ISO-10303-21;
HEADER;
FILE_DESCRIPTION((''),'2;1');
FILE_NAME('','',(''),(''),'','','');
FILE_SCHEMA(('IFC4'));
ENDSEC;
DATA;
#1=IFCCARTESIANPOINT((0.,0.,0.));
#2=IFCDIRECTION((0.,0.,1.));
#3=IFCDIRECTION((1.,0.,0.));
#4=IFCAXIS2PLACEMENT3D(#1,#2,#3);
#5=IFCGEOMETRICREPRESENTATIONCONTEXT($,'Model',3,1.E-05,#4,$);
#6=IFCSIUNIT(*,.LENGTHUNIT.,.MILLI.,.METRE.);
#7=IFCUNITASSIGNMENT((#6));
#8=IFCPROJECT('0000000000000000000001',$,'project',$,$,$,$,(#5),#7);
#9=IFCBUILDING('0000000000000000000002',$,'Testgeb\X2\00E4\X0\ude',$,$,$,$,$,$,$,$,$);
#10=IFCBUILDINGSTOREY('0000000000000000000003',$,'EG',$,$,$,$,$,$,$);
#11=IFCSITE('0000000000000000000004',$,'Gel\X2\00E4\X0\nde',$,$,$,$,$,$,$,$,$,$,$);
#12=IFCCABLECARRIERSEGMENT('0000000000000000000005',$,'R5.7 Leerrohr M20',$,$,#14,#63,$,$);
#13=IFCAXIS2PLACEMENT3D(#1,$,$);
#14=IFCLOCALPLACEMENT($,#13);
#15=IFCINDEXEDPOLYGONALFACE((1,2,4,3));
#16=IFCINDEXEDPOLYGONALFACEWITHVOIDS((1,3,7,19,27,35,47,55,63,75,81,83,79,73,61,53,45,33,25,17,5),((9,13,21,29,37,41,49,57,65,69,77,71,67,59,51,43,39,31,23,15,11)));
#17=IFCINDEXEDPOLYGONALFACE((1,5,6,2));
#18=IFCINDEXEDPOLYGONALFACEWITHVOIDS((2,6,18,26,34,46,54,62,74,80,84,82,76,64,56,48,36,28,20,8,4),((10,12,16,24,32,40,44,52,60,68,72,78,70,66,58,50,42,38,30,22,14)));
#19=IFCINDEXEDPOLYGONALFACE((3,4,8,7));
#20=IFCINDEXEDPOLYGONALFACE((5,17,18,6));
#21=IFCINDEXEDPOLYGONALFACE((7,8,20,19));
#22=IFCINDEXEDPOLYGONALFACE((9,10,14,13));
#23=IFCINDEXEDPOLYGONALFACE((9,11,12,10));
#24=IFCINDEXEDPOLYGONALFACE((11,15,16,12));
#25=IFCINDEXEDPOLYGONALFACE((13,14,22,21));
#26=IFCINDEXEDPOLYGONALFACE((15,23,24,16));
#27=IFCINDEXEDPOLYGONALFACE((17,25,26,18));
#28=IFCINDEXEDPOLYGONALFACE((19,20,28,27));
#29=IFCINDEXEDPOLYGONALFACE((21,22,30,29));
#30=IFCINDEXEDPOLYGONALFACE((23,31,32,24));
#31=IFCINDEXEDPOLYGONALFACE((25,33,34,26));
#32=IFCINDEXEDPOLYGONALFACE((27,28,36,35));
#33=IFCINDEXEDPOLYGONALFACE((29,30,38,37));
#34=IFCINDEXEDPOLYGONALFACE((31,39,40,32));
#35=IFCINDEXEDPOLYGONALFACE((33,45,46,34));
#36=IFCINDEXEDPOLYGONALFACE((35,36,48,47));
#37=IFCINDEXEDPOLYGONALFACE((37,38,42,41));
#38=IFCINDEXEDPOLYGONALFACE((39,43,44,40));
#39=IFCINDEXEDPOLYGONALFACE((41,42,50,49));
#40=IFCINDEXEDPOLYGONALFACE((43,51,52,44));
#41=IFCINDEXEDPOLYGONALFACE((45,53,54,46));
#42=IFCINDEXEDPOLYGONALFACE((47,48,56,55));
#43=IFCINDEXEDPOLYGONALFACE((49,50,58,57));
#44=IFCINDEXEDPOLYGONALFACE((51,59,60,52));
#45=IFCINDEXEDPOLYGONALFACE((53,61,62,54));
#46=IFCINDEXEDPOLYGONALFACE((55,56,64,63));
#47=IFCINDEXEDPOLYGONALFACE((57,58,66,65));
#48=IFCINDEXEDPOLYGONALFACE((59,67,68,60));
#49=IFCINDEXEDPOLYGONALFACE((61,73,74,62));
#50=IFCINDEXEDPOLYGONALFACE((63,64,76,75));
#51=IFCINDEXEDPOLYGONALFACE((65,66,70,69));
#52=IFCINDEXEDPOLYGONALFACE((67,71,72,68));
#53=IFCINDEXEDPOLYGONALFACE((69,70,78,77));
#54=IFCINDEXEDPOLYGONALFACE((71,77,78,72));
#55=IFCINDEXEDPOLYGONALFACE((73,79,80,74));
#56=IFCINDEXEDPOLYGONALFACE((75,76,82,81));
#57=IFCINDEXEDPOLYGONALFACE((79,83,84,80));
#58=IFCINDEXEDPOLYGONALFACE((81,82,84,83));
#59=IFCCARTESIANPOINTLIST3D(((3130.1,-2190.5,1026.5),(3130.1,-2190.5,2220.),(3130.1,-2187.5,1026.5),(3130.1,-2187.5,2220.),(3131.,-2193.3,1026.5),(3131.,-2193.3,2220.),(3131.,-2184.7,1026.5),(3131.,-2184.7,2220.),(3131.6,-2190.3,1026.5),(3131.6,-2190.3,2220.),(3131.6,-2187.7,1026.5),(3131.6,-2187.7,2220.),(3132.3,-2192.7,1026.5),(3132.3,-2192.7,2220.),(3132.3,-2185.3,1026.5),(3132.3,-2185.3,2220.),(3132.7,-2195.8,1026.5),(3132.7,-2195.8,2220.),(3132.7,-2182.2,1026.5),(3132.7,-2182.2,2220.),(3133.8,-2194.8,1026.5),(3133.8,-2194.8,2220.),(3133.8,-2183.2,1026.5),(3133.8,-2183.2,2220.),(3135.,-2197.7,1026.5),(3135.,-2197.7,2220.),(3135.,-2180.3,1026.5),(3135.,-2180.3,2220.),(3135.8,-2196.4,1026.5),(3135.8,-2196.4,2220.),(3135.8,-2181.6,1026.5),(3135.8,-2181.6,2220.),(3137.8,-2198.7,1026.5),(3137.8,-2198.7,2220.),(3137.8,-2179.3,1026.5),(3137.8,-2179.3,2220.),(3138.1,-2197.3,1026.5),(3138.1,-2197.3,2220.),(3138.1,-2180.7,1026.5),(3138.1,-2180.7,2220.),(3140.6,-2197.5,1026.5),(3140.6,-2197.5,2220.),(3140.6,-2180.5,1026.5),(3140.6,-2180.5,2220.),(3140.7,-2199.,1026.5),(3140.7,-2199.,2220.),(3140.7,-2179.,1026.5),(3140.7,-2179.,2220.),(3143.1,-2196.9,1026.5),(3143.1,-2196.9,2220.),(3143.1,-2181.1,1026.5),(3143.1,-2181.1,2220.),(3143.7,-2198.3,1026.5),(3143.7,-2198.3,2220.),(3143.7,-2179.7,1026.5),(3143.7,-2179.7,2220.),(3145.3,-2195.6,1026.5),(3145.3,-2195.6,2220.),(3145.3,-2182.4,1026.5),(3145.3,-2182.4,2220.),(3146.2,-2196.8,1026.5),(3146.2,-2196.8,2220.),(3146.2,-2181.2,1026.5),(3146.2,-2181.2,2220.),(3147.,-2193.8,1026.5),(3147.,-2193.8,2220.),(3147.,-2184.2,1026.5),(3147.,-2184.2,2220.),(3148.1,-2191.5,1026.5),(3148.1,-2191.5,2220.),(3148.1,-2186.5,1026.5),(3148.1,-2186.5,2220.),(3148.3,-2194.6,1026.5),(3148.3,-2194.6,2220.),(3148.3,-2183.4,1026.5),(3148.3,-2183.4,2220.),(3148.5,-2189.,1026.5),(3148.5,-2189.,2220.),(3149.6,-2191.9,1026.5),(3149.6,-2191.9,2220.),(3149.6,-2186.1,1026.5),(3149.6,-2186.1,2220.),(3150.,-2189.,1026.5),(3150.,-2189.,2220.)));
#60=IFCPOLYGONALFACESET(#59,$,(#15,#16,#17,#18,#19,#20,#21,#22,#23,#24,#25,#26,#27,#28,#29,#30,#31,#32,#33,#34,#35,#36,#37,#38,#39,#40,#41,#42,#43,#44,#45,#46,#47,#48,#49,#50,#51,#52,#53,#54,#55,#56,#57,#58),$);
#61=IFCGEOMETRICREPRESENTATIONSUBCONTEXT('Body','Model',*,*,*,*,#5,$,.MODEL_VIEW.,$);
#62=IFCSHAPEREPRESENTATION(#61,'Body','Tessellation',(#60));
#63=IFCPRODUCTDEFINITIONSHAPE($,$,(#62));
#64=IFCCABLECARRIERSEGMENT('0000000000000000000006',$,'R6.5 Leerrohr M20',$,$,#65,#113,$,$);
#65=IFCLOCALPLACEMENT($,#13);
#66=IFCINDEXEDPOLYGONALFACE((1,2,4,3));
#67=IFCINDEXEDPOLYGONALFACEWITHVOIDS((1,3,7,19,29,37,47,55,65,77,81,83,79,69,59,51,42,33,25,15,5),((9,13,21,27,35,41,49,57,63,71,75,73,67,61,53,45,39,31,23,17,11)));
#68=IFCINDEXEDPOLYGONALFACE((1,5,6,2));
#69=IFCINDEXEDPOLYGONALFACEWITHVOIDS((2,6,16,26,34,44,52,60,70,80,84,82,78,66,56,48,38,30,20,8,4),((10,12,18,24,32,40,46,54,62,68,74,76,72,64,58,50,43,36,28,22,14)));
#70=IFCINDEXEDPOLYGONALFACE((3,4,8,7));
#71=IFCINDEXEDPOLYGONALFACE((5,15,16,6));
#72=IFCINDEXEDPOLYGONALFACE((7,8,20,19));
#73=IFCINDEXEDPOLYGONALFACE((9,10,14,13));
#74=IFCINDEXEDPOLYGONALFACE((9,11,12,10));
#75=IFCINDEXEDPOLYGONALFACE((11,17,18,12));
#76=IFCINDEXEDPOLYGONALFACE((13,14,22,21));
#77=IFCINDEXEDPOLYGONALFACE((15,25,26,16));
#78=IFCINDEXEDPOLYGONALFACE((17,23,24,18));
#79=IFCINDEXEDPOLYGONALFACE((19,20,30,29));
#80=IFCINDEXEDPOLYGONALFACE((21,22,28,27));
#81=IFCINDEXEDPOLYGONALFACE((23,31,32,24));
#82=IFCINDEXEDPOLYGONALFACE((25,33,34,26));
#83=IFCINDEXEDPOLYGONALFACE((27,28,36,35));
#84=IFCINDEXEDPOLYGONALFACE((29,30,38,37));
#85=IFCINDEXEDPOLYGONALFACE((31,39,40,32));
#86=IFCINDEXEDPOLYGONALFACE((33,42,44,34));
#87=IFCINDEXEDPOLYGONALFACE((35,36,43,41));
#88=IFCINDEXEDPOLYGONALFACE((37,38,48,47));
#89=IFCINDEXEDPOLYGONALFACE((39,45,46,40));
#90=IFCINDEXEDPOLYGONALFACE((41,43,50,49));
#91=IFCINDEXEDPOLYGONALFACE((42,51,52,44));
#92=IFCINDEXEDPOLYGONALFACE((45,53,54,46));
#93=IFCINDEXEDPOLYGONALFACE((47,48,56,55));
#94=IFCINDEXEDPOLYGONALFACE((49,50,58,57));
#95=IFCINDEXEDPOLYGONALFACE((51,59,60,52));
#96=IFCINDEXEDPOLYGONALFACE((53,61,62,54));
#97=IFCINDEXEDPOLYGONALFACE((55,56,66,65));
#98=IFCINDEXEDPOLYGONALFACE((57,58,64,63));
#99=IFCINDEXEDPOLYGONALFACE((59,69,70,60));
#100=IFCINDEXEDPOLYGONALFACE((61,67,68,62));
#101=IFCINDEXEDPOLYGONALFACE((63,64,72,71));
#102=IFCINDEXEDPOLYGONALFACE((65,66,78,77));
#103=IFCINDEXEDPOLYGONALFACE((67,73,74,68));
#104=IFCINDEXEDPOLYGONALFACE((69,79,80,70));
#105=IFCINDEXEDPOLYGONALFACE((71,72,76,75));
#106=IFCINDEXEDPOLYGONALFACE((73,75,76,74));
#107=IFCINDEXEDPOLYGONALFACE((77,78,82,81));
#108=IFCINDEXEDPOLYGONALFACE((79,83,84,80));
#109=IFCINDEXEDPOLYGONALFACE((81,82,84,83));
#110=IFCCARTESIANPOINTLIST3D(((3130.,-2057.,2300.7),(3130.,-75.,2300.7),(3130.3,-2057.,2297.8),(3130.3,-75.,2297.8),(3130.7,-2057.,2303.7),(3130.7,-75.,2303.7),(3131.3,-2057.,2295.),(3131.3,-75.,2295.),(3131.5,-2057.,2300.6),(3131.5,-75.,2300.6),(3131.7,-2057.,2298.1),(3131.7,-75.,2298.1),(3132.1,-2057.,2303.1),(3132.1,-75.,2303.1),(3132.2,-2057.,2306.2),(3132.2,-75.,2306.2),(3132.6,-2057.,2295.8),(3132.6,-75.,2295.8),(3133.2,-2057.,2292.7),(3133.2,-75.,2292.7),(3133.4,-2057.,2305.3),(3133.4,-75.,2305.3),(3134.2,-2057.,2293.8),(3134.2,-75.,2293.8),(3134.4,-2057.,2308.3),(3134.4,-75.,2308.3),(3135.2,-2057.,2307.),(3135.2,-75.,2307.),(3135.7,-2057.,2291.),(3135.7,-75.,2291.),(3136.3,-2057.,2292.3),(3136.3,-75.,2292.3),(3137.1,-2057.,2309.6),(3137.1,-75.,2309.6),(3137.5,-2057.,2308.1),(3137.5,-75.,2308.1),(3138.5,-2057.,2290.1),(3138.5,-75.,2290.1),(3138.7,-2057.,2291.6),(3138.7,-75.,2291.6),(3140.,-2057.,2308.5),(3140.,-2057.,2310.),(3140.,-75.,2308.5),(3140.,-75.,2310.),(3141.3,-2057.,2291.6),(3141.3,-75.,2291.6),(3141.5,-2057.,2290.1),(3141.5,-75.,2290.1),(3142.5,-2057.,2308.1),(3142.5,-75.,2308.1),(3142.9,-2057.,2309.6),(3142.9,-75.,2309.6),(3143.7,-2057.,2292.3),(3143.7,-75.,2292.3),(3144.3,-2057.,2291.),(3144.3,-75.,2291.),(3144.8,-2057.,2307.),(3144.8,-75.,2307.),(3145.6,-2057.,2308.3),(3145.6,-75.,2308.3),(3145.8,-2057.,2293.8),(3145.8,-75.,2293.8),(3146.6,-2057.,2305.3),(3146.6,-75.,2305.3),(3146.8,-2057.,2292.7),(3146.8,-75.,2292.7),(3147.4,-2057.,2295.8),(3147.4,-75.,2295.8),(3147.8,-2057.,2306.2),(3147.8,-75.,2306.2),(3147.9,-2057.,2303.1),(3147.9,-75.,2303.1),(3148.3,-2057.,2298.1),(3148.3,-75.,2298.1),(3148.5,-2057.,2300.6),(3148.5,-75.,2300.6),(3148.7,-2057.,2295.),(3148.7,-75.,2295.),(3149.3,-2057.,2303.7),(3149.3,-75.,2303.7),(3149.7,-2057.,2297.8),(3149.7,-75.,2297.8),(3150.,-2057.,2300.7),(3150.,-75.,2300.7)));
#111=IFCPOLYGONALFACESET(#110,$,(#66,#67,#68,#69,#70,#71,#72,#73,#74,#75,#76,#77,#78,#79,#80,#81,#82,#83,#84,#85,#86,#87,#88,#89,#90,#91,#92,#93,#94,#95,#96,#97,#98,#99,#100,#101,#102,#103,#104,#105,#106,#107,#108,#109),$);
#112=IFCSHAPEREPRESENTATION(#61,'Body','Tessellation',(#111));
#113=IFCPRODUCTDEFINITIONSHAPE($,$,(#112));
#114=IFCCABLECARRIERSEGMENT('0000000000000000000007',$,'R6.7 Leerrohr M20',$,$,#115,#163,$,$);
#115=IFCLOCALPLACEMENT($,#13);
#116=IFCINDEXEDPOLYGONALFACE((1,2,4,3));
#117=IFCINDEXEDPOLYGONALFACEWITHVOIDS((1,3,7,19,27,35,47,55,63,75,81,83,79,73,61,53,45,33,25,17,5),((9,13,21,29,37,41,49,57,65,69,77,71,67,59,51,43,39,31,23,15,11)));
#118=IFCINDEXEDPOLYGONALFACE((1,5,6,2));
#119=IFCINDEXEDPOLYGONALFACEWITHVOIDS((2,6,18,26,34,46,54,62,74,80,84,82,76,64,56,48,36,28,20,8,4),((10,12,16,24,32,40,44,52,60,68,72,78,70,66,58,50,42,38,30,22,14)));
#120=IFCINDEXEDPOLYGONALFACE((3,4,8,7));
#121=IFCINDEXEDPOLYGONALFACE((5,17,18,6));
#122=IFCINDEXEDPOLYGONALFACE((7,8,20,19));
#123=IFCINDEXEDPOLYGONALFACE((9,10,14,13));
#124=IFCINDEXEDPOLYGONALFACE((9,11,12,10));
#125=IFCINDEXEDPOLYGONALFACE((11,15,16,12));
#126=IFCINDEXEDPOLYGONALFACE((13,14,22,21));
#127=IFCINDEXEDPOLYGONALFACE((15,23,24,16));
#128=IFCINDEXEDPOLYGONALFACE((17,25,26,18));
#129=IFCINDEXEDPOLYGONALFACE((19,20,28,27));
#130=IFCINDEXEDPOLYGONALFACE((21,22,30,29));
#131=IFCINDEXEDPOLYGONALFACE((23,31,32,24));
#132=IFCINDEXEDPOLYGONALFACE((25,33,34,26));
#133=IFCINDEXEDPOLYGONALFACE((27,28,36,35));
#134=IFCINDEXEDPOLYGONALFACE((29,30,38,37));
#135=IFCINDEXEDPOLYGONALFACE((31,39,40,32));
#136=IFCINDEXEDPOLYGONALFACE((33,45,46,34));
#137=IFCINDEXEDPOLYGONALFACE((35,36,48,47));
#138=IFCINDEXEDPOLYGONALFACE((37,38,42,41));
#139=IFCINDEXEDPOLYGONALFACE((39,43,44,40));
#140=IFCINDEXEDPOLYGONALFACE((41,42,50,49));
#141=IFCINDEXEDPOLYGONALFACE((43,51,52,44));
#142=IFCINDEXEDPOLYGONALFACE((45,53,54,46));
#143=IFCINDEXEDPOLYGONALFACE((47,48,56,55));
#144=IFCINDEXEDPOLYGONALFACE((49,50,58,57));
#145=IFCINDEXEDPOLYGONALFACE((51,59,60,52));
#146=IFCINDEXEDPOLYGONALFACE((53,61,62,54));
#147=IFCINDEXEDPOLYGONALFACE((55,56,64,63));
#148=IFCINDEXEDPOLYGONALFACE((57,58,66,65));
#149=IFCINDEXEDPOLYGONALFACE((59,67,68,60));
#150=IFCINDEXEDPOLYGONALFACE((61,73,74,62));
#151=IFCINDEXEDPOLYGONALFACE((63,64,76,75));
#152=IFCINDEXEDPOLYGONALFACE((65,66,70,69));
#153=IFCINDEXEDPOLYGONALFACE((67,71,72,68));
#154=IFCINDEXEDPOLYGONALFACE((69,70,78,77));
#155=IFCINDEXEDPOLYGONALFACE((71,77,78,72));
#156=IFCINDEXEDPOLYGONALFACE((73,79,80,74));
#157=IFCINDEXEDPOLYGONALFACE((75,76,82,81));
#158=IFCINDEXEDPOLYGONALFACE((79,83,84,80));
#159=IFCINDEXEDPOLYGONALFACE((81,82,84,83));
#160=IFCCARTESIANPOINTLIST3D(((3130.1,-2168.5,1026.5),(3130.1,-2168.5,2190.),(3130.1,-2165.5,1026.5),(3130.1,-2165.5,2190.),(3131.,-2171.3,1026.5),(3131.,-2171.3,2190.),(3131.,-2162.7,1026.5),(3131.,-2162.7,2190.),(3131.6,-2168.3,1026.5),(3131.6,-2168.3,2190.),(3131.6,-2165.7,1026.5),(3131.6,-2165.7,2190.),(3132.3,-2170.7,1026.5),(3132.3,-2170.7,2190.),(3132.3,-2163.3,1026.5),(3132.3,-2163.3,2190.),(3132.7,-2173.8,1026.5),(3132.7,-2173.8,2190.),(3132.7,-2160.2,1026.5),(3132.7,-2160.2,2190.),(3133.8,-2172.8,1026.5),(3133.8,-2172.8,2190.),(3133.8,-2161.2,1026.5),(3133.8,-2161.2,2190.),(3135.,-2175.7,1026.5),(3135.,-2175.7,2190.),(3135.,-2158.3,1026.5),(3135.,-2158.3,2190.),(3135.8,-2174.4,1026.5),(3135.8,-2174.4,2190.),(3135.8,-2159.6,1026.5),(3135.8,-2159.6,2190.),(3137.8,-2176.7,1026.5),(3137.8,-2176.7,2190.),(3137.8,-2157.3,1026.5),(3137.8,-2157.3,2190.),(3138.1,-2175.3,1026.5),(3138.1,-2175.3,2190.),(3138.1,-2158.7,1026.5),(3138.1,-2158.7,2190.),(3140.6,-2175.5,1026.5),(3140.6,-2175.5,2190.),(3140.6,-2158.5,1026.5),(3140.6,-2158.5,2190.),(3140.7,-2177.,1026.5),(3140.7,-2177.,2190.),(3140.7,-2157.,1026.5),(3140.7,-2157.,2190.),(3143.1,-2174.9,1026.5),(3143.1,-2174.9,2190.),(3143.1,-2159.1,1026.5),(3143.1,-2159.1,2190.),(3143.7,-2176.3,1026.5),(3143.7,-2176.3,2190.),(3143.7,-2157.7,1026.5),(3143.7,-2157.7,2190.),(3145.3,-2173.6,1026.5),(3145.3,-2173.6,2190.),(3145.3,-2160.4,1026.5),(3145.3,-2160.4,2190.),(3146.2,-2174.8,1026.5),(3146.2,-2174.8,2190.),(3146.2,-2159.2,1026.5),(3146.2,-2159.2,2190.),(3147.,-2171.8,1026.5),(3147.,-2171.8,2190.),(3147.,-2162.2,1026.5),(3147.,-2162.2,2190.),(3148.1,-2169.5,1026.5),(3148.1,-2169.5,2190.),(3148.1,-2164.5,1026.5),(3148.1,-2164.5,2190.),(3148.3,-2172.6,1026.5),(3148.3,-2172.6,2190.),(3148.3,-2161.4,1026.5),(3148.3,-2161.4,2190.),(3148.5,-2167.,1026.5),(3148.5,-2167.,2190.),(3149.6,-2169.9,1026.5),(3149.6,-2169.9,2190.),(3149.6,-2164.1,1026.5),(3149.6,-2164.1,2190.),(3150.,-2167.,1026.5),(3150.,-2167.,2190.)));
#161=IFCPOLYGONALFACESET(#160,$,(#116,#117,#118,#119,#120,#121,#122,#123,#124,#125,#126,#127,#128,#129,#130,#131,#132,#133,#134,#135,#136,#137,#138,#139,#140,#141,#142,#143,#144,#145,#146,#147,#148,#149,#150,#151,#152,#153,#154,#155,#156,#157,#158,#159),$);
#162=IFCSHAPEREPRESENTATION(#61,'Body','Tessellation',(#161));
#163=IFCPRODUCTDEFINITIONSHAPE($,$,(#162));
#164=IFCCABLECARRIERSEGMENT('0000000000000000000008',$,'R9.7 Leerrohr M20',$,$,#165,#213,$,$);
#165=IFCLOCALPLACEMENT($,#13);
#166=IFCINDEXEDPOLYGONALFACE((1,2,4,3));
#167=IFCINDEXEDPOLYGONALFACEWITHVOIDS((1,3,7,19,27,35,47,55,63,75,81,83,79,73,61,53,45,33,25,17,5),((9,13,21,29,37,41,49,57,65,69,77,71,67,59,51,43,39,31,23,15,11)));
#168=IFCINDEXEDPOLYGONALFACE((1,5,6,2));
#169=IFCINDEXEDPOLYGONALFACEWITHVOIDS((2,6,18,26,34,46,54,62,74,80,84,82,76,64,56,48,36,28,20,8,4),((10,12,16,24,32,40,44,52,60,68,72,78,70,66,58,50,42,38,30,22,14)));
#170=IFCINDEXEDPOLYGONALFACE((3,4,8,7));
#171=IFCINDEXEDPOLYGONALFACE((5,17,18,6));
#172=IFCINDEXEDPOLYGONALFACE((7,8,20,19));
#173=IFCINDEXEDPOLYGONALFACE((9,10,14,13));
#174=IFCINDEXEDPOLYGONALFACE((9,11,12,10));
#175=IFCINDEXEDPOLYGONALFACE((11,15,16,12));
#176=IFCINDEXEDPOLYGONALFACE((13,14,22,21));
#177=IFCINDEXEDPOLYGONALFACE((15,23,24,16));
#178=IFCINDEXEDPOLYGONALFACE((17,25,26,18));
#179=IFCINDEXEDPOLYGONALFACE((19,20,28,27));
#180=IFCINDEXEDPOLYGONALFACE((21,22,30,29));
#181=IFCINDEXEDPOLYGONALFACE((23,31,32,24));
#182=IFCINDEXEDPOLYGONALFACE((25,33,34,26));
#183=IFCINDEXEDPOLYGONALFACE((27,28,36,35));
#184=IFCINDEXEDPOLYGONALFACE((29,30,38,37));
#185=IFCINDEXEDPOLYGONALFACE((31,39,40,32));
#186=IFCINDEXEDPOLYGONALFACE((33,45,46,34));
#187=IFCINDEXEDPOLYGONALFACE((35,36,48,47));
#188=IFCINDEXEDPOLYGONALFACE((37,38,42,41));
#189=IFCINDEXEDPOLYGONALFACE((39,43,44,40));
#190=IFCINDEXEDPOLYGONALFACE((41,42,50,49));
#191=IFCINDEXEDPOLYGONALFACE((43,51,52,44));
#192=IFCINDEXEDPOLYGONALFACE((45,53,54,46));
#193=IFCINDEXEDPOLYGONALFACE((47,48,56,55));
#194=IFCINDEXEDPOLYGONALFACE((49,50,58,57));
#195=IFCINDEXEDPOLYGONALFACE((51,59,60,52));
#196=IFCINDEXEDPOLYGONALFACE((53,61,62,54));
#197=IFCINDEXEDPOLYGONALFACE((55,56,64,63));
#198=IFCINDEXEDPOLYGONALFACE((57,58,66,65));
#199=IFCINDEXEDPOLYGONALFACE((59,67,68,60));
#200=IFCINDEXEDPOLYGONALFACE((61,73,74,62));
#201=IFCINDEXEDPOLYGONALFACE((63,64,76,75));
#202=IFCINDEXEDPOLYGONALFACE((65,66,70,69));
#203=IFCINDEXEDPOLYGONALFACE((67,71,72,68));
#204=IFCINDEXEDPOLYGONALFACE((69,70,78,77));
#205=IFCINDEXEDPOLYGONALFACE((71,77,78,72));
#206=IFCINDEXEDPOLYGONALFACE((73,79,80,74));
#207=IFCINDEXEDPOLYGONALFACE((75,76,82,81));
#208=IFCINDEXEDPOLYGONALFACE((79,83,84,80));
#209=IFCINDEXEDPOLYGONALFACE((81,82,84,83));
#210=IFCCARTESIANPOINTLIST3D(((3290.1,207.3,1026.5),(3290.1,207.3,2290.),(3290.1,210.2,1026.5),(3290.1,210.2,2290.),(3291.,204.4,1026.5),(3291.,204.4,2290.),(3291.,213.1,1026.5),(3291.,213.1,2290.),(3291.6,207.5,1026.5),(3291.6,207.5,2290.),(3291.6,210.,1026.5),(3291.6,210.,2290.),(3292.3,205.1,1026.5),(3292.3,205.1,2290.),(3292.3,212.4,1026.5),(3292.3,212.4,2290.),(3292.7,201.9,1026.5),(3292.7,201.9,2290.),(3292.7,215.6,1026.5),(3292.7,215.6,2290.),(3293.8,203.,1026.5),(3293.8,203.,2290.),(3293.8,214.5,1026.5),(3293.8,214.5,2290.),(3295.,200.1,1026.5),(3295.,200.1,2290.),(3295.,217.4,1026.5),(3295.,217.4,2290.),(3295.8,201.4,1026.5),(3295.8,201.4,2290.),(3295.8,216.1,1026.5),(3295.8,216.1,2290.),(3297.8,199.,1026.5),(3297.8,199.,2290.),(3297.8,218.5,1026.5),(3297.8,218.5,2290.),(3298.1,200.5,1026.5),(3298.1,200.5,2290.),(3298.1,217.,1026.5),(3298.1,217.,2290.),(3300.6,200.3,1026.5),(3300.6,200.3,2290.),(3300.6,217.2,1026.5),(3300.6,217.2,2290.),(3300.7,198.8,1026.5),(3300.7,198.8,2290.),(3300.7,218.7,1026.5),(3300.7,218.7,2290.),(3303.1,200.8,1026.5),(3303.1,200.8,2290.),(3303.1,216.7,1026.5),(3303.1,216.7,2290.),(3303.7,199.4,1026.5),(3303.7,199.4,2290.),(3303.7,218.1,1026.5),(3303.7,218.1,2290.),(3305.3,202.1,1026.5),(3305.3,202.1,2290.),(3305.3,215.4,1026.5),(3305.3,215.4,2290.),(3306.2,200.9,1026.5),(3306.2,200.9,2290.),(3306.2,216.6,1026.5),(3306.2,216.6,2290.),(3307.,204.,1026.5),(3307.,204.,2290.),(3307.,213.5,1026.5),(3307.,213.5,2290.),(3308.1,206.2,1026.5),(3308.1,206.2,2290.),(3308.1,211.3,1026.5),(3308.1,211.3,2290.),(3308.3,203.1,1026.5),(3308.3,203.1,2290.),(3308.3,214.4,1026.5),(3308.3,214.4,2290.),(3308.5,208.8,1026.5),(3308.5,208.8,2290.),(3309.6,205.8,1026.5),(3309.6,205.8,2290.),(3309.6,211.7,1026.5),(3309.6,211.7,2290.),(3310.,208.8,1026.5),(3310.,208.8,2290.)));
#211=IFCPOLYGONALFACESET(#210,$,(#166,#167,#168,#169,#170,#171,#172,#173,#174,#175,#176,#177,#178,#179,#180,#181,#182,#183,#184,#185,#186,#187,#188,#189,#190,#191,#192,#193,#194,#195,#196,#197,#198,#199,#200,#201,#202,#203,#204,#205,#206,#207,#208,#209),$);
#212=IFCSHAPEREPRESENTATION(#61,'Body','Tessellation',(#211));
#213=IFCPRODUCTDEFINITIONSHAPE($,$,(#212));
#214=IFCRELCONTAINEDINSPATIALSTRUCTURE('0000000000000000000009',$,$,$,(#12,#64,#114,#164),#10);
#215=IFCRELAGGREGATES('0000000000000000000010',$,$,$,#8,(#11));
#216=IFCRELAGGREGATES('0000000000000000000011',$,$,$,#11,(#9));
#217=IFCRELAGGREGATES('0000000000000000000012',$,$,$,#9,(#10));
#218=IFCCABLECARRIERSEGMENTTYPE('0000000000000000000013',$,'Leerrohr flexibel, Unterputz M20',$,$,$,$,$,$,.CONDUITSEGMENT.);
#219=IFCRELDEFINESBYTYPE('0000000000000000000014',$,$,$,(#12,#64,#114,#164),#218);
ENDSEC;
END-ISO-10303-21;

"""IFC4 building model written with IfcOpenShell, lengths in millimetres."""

from ifc_helpers import new_model, si_unit, frame, origin_with_axes, place, context, subcontext, project, spatial, hollow_circle, extrude, type_object, element, save


model = new_model("IFC4")

# Units and contexts
model_context = context("Model", 3, precision=1e-05, world=origin_with_axes())
body_context = subcontext(model_context, "Body", "Model", "MODEL_VIEW")
ifc_project = project(units=[si_unit("LENGTHUNIT", "METRE", prefix="MILLI")], contexts=[model_context])

# Site, building, storey
site = spatial("IfcSite", under=ifc_project, Name="Gelände")
building = spatial("IfcBuilding", under=site, Name="Testgebäude")
storey = spatial("IfcBuildingStorey", under=building, Name="EG")

# Cable carrier segments
cable_carrier_segment_type_1 = type_object("IfcCableCarrierSegmentType", Name="Leerrohr flexibel, Unterputz M20", PredefinedType="CONDUITSEGMENT")
cable_carrier_segment_1_placement = place(None, frame((3140.0, -2189.0, 2220.0), z_axis=(0.0, 0.0, -1.0), x_axis=(1.0, 0.0, 0.0)))
element("IfcCableCarrierSegment", 1, at=cable_carrier_segment_1_placement, inside=storey, type_object=cable_carrier_segment_type_1, Name="R5.7 Leerrohr M20", context=body_context, shape_type="SweptSolid", body=[
    extrude(hollow_circle(Radius=10.0, WallThickness=1.5), None, (0.0, 0.0, 1.0), 1193.5),
])
cable_carrier_segment_2_placement = place(None, frame((3140.0, -75.0, 2300.0), z_axis=(0.0, -1.0, 0.0), x_axis=(0.0, 0.0, 1.0)))
element("IfcCableCarrierSegment", 2, at=cable_carrier_segment_2_placement, inside=storey, type_object=cable_carrier_segment_type_1, Name="R6.5 Leerrohr M20", context=body_context, shape_type="SweptSolid", body=[
    extrude(hollow_circle(Radius=10.0, WallThickness=1.5), None, (0.0, 0.0, 1.0), 1982.0),
])
cable_carrier_segment_3_placement = place(None, frame((3140.0, -2167.0, 2190.0), z_axis=(0.0, 0.0, -1.0), x_axis=(1.0, 0.0, 0.0)))
element("IfcCableCarrierSegment", 3, at=cable_carrier_segment_3_placement, inside=storey, type_object=cable_carrier_segment_type_1, Name="R6.7 Leerrohr M20", context=body_context, shape_type="SweptSolid", body=[
    extrude(hollow_circle(Radius=10.0, WallThickness=1.5), None, (0.0, 0.0, 1.0), 1163.5),
])
cable_carrier_segment_4_placement = place(None, frame((3300.0, 208.8, 2290.0), z_axis=(0.0, 0.0, -1.0), x_axis=(1.0, 0.0, 0.0)))
element("IfcCableCarrierSegment", 4, at=cable_carrier_segment_4_placement, inside=storey, type_object=cable_carrier_segment_type_1, Name="R9.7 Leerrohr M20", context=body_context, shape_type="SweptSolid", body=[
    extrude(hollow_circle(Radius=10.0, WallThickness=1.5), None, (0.0, 0.0, 1.0), 1263.5),
])

save(model, "model.ifc")
